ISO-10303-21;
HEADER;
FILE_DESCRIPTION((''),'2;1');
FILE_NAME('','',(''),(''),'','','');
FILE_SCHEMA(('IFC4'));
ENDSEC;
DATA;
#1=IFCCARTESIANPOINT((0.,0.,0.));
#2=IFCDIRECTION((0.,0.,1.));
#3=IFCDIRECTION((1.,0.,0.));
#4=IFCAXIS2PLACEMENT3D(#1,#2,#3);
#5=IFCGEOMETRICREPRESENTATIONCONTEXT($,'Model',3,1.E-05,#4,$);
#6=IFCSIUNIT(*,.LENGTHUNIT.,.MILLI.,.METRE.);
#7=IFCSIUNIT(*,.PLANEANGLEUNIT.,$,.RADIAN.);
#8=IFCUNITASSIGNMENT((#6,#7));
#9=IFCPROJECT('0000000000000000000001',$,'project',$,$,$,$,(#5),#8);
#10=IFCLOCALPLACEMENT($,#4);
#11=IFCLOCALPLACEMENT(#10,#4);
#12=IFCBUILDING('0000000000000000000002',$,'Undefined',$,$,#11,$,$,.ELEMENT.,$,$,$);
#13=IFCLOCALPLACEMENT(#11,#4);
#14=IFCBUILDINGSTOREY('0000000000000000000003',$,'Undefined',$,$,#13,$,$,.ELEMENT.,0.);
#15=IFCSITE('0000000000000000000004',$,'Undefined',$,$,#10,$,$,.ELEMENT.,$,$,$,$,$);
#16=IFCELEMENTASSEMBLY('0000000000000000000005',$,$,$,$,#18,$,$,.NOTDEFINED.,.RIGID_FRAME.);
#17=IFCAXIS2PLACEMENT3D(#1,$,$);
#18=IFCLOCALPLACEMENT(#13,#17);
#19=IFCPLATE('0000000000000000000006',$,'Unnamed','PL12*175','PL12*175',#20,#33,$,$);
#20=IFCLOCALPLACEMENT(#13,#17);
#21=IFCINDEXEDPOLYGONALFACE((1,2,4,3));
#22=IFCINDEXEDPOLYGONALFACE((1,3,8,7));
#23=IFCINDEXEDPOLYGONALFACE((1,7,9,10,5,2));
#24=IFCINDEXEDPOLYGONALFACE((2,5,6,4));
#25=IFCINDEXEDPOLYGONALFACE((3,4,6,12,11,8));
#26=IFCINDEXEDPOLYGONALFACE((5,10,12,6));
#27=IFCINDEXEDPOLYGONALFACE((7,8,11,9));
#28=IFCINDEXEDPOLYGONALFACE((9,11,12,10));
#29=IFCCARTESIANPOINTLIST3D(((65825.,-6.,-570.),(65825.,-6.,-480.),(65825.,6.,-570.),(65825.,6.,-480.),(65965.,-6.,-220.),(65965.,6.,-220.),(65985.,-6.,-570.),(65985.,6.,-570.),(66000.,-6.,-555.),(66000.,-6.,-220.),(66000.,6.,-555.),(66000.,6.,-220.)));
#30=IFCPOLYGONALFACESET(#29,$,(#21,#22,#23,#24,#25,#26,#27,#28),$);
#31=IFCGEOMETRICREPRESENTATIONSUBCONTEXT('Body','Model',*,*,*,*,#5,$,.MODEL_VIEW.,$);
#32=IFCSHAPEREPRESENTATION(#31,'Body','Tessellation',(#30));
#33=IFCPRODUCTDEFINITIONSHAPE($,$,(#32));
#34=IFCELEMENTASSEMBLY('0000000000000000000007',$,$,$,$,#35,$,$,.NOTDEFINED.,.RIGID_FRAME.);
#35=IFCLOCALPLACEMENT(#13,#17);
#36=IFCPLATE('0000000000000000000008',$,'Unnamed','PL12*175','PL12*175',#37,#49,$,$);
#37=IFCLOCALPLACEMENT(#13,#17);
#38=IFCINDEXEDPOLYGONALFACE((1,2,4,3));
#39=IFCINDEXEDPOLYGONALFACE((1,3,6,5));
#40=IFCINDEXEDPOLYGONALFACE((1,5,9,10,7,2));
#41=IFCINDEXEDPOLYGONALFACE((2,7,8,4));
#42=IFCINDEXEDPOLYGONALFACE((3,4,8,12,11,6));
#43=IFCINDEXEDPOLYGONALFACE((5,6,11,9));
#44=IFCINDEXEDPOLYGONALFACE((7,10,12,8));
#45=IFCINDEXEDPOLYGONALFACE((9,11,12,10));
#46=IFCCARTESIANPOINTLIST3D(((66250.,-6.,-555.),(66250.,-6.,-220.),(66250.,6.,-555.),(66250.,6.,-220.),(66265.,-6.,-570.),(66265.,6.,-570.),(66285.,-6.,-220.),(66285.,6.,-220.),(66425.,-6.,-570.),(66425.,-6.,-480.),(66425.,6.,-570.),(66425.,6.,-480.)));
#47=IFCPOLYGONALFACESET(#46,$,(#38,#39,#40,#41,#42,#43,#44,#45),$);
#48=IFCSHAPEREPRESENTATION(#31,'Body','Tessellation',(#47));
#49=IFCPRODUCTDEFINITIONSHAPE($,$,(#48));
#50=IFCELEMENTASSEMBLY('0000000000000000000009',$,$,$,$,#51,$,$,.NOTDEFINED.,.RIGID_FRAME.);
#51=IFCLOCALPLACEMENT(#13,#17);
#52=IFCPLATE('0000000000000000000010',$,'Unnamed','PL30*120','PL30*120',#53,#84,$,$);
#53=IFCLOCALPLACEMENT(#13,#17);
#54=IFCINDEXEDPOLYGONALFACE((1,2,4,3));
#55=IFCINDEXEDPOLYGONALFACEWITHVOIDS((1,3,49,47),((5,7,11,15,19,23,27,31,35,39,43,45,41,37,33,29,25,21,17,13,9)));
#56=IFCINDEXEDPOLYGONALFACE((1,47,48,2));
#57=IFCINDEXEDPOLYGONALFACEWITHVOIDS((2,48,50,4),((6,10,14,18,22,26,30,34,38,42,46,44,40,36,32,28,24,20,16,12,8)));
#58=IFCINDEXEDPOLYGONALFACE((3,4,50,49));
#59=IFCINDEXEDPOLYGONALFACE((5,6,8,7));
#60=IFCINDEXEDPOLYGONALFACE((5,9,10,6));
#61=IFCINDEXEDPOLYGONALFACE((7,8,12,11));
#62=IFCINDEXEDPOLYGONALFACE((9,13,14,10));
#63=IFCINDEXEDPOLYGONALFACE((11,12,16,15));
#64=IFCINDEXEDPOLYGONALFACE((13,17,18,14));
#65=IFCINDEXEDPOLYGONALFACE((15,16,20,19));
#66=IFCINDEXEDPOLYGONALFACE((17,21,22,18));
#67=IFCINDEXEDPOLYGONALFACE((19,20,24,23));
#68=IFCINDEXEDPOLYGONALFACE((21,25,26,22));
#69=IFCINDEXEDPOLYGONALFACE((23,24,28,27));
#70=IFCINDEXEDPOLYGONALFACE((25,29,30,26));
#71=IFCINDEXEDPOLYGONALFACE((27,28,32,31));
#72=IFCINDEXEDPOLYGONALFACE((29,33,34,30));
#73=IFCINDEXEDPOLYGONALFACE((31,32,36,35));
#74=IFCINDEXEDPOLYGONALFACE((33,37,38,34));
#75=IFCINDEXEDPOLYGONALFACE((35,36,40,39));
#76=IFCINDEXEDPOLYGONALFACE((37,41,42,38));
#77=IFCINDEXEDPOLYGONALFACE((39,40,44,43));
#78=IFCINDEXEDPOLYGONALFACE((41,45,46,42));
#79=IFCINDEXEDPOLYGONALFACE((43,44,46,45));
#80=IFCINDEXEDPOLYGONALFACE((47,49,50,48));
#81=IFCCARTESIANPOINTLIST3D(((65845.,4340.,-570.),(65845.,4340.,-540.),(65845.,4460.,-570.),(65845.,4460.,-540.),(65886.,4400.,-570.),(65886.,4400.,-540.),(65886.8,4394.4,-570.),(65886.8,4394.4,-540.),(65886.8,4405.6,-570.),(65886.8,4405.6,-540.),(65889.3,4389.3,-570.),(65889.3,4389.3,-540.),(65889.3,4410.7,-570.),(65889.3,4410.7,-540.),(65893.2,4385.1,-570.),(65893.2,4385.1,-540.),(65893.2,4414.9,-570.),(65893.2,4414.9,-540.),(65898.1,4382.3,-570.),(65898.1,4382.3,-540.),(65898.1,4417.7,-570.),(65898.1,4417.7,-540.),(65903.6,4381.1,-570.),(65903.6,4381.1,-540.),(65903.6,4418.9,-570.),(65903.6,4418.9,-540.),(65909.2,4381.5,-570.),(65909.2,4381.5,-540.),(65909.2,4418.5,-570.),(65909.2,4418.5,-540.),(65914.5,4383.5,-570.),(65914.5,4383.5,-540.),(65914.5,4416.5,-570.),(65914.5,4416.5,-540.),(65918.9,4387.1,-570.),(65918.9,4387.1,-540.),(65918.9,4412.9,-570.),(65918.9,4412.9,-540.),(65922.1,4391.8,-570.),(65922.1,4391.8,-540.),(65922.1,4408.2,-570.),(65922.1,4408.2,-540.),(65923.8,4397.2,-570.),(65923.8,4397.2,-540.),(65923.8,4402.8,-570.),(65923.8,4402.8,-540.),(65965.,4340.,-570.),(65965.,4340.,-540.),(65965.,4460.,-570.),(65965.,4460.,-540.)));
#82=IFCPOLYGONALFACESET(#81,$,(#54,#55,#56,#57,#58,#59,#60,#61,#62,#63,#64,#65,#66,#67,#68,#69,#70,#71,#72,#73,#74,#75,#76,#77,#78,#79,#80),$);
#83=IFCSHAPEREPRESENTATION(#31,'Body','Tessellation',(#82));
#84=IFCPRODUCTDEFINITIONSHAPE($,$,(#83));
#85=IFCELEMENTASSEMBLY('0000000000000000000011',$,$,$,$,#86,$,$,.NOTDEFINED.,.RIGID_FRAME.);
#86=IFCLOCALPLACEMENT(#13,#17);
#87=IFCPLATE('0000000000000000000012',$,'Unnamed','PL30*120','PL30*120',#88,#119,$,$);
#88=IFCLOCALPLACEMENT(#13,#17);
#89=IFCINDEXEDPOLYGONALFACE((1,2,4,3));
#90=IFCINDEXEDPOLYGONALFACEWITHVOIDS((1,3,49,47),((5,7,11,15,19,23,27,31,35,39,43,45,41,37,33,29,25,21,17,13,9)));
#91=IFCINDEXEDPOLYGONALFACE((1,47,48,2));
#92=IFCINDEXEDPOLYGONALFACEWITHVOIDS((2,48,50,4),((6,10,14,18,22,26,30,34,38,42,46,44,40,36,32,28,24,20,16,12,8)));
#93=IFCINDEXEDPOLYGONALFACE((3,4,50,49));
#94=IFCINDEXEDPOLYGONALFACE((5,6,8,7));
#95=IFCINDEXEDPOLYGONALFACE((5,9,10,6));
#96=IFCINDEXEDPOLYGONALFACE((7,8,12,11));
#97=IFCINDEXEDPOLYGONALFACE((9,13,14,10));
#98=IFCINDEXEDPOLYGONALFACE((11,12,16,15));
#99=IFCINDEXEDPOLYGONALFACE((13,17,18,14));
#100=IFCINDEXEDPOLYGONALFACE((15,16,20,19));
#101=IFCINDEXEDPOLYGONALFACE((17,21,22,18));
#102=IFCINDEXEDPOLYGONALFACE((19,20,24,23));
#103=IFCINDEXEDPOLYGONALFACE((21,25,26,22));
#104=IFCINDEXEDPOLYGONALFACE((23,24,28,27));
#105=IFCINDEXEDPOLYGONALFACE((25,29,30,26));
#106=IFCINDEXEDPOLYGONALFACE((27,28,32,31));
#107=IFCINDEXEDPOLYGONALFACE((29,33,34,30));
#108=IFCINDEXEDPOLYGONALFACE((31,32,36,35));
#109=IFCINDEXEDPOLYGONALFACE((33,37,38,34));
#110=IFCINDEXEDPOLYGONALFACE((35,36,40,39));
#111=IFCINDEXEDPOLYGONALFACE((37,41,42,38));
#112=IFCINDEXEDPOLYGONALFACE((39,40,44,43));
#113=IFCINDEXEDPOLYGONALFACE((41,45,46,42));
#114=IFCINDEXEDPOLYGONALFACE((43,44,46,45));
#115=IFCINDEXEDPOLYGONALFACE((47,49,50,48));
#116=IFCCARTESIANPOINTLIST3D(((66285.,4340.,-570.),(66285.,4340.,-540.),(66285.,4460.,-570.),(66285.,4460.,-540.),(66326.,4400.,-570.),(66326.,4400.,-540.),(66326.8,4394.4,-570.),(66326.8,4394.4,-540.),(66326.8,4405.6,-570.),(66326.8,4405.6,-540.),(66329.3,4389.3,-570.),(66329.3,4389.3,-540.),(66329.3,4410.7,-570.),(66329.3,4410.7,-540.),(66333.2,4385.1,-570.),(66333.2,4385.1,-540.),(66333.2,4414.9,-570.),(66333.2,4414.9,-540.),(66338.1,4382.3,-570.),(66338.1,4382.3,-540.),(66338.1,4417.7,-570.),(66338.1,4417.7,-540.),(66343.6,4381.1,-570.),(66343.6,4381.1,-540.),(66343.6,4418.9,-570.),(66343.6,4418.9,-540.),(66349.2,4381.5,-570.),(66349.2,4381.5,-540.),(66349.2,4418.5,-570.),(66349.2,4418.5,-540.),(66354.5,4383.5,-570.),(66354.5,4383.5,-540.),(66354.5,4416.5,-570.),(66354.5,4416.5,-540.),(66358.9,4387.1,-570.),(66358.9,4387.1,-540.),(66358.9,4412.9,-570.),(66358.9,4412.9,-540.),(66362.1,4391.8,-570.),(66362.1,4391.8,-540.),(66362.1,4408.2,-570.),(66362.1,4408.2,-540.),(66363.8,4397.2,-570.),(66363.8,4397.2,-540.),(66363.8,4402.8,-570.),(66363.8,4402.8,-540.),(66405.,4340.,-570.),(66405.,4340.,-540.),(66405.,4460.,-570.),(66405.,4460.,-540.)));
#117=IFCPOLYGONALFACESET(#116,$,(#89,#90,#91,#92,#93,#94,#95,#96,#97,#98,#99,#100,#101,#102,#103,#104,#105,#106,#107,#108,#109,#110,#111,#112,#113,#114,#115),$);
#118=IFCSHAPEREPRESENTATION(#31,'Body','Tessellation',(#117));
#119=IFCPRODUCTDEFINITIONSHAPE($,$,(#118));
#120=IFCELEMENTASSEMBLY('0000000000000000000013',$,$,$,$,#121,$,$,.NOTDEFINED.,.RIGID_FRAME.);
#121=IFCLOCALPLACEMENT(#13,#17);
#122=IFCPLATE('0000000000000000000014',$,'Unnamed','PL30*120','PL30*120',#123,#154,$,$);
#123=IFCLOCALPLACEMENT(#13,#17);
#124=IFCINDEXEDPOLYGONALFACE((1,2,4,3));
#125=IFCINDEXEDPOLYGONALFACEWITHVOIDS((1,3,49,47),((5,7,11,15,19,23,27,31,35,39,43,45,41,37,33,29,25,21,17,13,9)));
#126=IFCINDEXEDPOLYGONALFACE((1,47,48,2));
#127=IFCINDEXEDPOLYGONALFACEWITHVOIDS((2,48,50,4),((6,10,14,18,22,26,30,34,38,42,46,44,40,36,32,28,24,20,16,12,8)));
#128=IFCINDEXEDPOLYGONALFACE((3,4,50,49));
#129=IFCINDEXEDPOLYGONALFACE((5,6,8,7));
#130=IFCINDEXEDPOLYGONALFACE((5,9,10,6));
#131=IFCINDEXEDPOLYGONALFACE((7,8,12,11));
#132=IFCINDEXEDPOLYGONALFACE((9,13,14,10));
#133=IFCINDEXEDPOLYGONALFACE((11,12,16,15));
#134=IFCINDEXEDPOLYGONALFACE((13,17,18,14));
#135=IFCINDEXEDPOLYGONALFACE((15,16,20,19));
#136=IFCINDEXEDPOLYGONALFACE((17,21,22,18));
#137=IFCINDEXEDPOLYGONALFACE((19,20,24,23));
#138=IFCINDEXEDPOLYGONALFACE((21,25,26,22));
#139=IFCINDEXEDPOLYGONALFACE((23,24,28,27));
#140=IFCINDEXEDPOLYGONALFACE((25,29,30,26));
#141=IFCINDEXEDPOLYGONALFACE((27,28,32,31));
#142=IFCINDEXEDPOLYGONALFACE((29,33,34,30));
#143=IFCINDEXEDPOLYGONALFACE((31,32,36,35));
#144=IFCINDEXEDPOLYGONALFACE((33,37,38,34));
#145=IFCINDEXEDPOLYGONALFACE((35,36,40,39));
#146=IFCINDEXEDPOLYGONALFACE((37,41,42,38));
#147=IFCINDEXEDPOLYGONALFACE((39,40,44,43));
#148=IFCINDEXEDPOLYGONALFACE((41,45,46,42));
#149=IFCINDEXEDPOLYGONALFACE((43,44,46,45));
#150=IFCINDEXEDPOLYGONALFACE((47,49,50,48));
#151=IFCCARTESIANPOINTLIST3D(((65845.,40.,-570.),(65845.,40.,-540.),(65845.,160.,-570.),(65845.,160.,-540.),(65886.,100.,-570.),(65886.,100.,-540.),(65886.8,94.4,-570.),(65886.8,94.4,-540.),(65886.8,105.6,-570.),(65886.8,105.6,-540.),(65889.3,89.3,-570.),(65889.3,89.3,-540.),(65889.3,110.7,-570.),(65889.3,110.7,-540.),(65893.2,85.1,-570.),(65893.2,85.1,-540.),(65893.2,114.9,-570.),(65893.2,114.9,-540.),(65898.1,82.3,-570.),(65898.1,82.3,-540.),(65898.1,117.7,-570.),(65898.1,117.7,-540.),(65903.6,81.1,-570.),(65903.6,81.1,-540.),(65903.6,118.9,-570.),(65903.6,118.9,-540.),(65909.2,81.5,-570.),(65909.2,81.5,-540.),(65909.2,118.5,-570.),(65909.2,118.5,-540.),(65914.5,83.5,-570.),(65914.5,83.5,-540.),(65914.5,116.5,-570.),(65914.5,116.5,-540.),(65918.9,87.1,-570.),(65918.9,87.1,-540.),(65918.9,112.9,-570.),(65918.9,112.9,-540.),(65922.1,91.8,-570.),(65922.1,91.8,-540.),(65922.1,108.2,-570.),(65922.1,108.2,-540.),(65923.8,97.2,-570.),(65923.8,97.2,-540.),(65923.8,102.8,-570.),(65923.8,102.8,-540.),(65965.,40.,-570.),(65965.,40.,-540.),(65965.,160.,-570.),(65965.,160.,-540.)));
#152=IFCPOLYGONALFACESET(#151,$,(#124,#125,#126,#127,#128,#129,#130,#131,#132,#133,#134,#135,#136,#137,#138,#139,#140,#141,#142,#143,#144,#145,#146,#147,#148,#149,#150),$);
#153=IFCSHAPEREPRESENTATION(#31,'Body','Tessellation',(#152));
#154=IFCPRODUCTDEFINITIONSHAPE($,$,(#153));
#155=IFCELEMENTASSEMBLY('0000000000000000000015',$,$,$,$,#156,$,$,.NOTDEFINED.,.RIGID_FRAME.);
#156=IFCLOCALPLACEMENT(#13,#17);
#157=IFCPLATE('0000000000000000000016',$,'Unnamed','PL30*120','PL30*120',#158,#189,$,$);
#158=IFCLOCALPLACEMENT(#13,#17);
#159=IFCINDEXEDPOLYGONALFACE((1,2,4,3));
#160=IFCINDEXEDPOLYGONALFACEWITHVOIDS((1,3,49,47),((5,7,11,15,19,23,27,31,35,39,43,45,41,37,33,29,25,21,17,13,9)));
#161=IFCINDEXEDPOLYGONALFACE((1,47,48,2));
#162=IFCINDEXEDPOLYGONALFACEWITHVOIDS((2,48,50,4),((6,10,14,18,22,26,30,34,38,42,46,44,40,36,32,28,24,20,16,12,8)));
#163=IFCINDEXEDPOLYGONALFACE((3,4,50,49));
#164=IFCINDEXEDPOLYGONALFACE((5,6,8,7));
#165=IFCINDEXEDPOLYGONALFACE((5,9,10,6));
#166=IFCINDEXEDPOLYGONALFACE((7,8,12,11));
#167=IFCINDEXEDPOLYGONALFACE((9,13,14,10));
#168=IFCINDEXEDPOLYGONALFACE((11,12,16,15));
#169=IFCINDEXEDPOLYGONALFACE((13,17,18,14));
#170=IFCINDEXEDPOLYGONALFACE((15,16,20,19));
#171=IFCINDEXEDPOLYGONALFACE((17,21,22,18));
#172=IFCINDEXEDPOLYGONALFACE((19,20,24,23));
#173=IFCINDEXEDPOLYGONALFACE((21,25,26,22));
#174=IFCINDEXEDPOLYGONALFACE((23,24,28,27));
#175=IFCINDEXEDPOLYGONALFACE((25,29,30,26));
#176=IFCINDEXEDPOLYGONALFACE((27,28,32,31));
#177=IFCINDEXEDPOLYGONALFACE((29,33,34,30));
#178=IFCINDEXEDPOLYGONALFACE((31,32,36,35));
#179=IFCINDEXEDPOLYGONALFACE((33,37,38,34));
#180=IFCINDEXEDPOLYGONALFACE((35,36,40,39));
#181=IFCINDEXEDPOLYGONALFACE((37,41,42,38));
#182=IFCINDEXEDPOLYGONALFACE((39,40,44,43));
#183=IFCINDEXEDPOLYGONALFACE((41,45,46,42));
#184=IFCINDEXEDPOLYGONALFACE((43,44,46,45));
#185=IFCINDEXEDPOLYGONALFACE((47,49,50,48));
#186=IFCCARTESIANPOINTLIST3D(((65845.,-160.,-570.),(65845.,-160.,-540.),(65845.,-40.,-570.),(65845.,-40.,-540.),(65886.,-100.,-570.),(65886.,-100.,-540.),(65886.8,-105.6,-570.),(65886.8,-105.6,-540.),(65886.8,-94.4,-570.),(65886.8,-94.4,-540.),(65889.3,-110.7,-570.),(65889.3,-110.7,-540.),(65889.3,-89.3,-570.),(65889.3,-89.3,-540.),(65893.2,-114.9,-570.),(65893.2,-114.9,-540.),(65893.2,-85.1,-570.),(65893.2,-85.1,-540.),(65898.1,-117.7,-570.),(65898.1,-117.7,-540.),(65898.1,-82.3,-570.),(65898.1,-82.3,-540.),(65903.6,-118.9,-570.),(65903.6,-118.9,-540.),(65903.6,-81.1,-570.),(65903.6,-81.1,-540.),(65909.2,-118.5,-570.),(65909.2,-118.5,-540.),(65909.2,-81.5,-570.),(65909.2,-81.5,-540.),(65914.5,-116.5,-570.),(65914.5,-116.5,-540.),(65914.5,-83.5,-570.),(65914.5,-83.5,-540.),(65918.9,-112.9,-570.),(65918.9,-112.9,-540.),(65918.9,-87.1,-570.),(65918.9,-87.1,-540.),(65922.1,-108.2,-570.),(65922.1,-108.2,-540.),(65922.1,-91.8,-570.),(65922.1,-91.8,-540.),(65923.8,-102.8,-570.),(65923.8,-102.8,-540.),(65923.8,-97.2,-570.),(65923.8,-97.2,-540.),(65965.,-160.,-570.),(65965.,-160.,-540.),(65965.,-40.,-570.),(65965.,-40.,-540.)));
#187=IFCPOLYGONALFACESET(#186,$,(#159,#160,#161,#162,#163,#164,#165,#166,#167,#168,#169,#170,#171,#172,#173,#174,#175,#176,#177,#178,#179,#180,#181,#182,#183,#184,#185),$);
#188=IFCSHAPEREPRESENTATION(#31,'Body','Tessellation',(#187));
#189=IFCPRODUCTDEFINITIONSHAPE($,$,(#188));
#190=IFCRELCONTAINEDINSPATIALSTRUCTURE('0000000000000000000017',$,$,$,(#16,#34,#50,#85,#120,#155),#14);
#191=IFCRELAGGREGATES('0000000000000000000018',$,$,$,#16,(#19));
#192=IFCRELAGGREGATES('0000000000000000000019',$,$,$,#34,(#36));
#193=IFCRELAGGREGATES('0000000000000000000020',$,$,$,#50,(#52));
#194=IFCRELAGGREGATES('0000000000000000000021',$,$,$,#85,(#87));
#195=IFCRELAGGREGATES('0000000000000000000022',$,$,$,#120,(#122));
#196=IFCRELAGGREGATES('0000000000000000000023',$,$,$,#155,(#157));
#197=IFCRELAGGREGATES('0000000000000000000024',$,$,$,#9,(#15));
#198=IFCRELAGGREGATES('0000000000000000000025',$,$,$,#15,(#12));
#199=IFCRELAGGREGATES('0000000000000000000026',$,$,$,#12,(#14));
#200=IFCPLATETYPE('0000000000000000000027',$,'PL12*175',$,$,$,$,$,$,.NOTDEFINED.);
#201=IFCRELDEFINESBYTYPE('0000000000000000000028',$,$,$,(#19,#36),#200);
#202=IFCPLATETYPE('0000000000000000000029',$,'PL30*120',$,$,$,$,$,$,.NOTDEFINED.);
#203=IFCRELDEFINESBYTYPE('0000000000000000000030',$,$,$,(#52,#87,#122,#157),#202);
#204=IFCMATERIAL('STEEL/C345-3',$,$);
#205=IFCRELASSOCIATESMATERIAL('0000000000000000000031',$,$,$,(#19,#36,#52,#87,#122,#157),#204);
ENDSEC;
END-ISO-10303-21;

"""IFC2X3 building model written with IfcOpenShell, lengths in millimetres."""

from ifc_helpers import new_model, si_unit, frame, origin_with_axes, origin_2d_with_axis, place, context, subcontext, project, spatial, polyline, circle, outline, extrude, boolean, material, type_object, element, aggregate, save


model = new_model("IFC2X3")

# Units and contexts
model_context = context("Model", 3, precision=1e-05, world=origin_with_axes())
body_context = subcontext(model_context, "Body", "Model", "MODEL_VIEW")
ifc_project = project(units=[si_unit("LENGTHUNIT", "METRE", prefix="MILLI"), si_unit("PLANEANGLEUNIT", "RADIAN")], contexts=[model_context])

# Site, building, storey
site_placement = place(None, origin_with_axes())
site = spatial("IfcSite", under=ifc_project, at=site_placement, Name="Undefined", CompositionType="ELEMENT")
building_placement = place(site_placement, origin_with_axes())
building = spatial("IfcBuilding", under=site, at=building_placement, Name="Undefined", CompositionType="ELEMENT")
storey_placement = place(building_placement, origin_with_axes())
storey = spatial("IfcBuildingStorey", under=building, at=storey_placement, Name="Undefined", CompositionType="ELEMENT", Elevation=0.0)

# Shared definitions
ifc_material_1 = material(Name="STEEL/C345-3")

# Element assemblies, plates
assembly_1_placement = place(storey_placement, origin_with_axes())
assembly_1 = element("IfcElementAssembly", 1, at=assembly_1_placement, inside=storey, AssemblyPlace="NOTDEFINED", PredefinedType="RIGID_FRAME")
plate_type_1 = type_object("IfcPlateType", Name="PL12*175", PredefinedType="NOTDEFINED")
plate_1_placement = place(assembly_1_placement, frame((65825.0, 0.0, -570.0), z_axis=(0.0, -1.0, 0.0), x_axis=(1.0, 0.0, 0.0)))
plate_1 = element("IfcPlate", 2, at=plate_1_placement, type_object=plate_type_1, material=ifc_material_1, Name="Unnamed", Description="PL12*175", ObjectType="PL12*175", context=body_context, shape_type="SweptSolid", body=[
    extrude(outline(polyline([(0.0, 0.0), (160.0, 0.0), (175.0, 15.0), (175.0, 350.0), (140.0, 350.0), (0.0, 90.0), (0.0, 0.0)])), frame((0.0, 0.0, -6.0), z_axis=(0.0, 0.0, 1.0), x_axis=(1.0, 0.0, 0.0)), (0.0, 0.0, 1.0), 12.0),
])
aggregate(assembly_1, [plate_1])
assembly_2_placement = place(storey_placement, origin_with_axes())
assembly_2 = element("IfcElementAssembly", 3, at=assembly_2_placement, inside=storey, AssemblyPlace="NOTDEFINED", PredefinedType="RIGID_FRAME")
plate_2_placement = place(assembly_2_placement, frame((66425.0, 0.0, -570.0), z_axis=(0.0, 1.0, 0.0), x_axis=(-1.0, 0.0, 0.0)))
plate_2 = element("IfcPlate", 4, at=plate_2_placement, type_object=plate_type_1, material=ifc_material_1, Name="Unnamed", Description="PL12*175", ObjectType="PL12*175", context=body_context, shape_type="SweptSolid", body=[
    extrude(outline(polyline([(0.0, 0.0), (160.0, 0.0), (175.0, 15.0), (175.0, 350.0), (140.0, 350.0), (0.0, 90.0), (0.0, 0.0)])), frame((0.0, 0.0, -6.0), z_axis=(0.0, 0.0, 1.0), x_axis=(1.0, 0.0, 0.0)), (0.0, 0.0, 1.0), 12.0),
])
aggregate(assembly_2, [plate_2])
assembly_3_placement = place(storey_placement, origin_with_axes())
assembly_3 = element("IfcElementAssembly", 5, at=assembly_3_placement, inside=storey, AssemblyPlace="NOTDEFINED", PredefinedType="RIGID_FRAME")
plate_type_2 = type_object("IfcPlateType", Name="PL30*120", PredefinedType="NOTDEFINED")
plate_3_placement = place(assembly_3_placement, frame((65845.0, 4340.0, -555.0), z_axis=(0.0, 0.0, -1.0), x_axis=(0.0, 1.0, 0.0)))
plate_3 = element("IfcPlate", 6, at=plate_3_placement, type_object=plate_type_2, material=ifc_material_1, Name="Unnamed", Description="PL30*120", ObjectType="PL30*120", context=body_context, shape_type="CSG", body=[
    boolean("DIFFERENCE", extrude(outline(polyline([(0.0, 0.0), (120.0, 0.0), (120.0, 120.0), (0.0, 120.0), (0.0, 0.0)])), frame((0.0, 0.0, -15.0), z_axis=(0.0, 0.0, 1.0), x_axis=(1.0, 0.0, 0.0)), (0.0, 0.0, 1.0), 30.0), extrude(circle(Radius=19.0, at=origin_2d_with_axis()), frame((60.0, 60.0, -45.0), z_axis=(0.0, 0.0, 1.0), x_axis=(0.0, -1.0, 0.0)), (0.0, 0.0, 1.0), 80.0)),
])
aggregate(assembly_3, [plate_3])
assembly_4_placement = place(storey_placement, origin_with_axes())
assembly_4 = element("IfcElementAssembly", 7, at=assembly_4_placement, inside=storey, AssemblyPlace="NOTDEFINED", PredefinedType="RIGID_FRAME")
plate_4_placement = place(assembly_4_placement, frame((66285.0, 4340.0, -555.0), z_axis=(0.0, 0.0, -1.0), x_axis=(0.0, 1.0, 0.0)))
plate_4 = element("IfcPlate", 8, at=plate_4_placement, type_object=plate_type_2, material=ifc_material_1, Name="Unnamed", Description="PL30*120", ObjectType="PL30*120", context=body_context, shape_type="CSG", body=[
    boolean("DIFFERENCE", extrude(outline(polyline([(0.0, 0.0), (120.0, 0.0), (120.0, 120.0), (0.0, 120.0), (0.0, 0.0)])), frame((0.0, 0.0, -15.0), z_axis=(0.0, 0.0, 1.0), x_axis=(1.0, 0.0, 0.0)), (0.0, 0.0, 1.0), 30.0), extrude(circle(Radius=19.0, at=origin_2d_with_axis()), frame((60.0, 60.0, -45.0), z_axis=(0.0, 0.0, 1.0), x_axis=(0.0, -1.0, 0.0)), (0.0, 0.0, 1.0), 80.0)),
])
aggregate(assembly_4, [plate_4])
assembly_5_placement = place(storey_placement, origin_with_axes())
assembly_5 = element("IfcElementAssembly", 9, at=assembly_5_placement, inside=storey, AssemblyPlace="NOTDEFINED", PredefinedType="RIGID_FRAME")
plate_5_placement = place(assembly_5_placement, frame((65845.0, 40.0, -555.0), z_axis=(0.0, 0.0, -1.0), x_axis=(0.0, 1.0, 0.0)))
plate_5 = element("IfcPlate", 10, at=plate_5_placement, type_object=plate_type_2, material=ifc_material_1, Name="Unnamed", Description="PL30*120", ObjectType="PL30*120", context=body_context, shape_type="CSG", body=[
    boolean("DIFFERENCE", extrude(outline(polyline([(0.0, 0.0), (120.0, 0.0), (120.0, 120.0), (0.0, 120.0), (0.0, 0.0)])), frame((0.0, 0.0, -15.0), z_axis=(0.0, 0.0, 1.0), x_axis=(1.0, 0.0, 0.0)), (0.0, 0.0, 1.0), 30.0), extrude(circle(Radius=19.0, at=origin_2d_with_axis()), frame((60.0, 60.0, -45.0), z_axis=(0.0, 0.0, 1.0), x_axis=(0.0, -1.0, 0.0)), (0.0, 0.0, 1.0), 80.0)),
])
aggregate(assembly_5, [plate_5])
assembly_6_placement = place(storey_placement, origin_with_axes())
assembly_6 = element("IfcElementAssembly", 11, at=assembly_6_placement, inside=storey, AssemblyPlace="NOTDEFINED", PredefinedType="RIGID_FRAME")
plate_6_placement = place(assembly_6_placement, frame((65845.0, -160.0, -555.0), z_axis=(0.0, 0.0, -1.0), x_axis=(0.0, 1.0, 0.0)))
plate_6 = element("IfcPlate", 12, at=plate_6_placement, type_object=plate_type_2, material=ifc_material_1, Name="Unnamed", Description="PL30*120", ObjectType="PL30*120", context=body_context, shape_type="CSG", body=[
    boolean("DIFFERENCE", extrude(outline(polyline([(0.0, 0.0), (120.0, 0.0), (120.0, 120.0), (0.0, 120.0), (0.0, 0.0)])), frame((0.0, 0.0, -15.0), z_axis=(0.0, 0.0, 1.0), x_axis=(1.0, 0.0, 0.0)), (0.0, 0.0, 1.0), 30.0), extrude(circle(Radius=19.0, at=origin_2d_with_axis()), frame((60.0, 60.0, -45.0), z_axis=(0.0, 0.0, 1.0), x_axis=(0.0, -1.0, 0.0)), (0.0, 0.0, 1.0), 80.0)),
])
aggregate(assembly_6, [plate_6])

save(model, "model.ifc")
